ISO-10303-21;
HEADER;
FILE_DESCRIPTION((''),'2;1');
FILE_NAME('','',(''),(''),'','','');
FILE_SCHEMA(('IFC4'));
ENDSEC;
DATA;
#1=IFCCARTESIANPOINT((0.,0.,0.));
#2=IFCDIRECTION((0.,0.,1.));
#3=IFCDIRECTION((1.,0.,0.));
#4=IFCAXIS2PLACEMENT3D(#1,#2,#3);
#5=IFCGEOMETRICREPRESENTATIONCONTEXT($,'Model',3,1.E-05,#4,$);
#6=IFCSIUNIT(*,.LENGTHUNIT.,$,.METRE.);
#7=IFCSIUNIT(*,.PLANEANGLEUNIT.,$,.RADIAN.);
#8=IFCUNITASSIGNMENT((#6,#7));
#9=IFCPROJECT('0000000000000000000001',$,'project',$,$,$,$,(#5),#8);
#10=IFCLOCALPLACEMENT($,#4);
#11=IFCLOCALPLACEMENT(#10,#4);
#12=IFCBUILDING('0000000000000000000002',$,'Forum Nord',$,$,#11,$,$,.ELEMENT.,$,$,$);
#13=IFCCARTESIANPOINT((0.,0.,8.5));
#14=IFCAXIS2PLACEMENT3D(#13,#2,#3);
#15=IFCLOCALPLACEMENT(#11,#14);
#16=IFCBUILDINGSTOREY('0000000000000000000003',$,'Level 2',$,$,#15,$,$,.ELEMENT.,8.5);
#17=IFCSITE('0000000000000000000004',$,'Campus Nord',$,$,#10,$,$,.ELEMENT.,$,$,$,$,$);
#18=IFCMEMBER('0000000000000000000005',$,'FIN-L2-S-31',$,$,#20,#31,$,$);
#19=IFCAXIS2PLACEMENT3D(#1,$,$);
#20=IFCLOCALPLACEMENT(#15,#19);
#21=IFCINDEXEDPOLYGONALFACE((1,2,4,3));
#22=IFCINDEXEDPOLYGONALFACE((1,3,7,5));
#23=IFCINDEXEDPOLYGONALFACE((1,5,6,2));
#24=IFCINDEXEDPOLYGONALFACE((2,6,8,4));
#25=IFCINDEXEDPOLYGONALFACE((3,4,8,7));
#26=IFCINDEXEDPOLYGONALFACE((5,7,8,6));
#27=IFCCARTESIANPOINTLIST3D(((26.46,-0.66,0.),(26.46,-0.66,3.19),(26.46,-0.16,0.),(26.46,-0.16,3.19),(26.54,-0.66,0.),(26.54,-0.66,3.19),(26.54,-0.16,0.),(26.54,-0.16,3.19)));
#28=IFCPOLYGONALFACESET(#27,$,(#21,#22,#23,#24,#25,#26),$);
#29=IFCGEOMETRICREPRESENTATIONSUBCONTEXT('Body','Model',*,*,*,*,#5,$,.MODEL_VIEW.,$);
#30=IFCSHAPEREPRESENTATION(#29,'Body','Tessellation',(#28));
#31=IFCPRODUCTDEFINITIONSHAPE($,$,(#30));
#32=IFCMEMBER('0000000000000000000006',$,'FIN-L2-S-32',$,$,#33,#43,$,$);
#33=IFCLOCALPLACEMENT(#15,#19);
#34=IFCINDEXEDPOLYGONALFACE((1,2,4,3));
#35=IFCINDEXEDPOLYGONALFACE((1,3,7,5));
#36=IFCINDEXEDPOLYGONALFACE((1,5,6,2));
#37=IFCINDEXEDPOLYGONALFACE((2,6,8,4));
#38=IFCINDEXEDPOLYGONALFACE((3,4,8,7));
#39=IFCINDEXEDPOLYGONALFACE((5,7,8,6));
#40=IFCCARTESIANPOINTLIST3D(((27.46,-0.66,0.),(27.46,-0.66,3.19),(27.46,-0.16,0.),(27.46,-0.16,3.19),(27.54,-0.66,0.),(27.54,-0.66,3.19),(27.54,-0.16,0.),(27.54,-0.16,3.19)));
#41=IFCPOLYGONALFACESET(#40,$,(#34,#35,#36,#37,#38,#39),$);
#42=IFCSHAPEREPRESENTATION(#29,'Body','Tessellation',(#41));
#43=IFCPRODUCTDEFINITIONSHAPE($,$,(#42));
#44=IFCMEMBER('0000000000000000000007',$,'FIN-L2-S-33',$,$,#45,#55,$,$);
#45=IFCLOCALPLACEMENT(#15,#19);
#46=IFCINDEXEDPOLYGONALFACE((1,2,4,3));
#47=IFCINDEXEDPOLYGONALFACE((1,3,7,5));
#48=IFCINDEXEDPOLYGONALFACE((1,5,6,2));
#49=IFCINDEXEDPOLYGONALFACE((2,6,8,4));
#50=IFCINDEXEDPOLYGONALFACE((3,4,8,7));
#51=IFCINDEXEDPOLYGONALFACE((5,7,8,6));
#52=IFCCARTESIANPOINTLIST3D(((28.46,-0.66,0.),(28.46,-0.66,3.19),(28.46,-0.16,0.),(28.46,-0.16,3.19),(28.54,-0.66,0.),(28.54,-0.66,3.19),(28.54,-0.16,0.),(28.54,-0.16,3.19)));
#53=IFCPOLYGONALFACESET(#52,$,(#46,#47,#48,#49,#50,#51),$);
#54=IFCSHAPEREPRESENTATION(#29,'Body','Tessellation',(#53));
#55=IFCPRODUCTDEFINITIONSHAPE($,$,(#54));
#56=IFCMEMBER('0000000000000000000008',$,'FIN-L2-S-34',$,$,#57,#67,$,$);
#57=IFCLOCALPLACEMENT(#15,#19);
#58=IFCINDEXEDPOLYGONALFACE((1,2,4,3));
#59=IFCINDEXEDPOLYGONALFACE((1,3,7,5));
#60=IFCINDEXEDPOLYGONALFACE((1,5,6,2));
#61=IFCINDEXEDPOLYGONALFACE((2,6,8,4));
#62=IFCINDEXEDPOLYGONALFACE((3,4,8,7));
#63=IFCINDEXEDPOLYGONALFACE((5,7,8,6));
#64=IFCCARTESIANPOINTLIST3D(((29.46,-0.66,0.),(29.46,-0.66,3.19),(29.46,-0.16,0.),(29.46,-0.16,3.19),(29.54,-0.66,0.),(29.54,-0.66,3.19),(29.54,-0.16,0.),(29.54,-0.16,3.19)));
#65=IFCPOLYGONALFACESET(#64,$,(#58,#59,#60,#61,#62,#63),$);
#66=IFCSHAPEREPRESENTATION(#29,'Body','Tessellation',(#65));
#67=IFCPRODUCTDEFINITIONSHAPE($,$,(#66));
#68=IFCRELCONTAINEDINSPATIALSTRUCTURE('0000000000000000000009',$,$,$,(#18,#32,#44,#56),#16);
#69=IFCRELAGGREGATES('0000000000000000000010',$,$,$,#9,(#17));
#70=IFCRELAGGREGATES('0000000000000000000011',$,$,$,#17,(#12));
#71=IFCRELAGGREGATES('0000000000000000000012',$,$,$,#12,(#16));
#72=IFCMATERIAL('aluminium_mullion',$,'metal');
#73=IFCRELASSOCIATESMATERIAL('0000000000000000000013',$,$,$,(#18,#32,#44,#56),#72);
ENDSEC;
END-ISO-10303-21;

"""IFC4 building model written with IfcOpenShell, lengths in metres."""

from ifc_helpers import new_model, si_unit, frame, origin_with_axes, place, context, subcontext, project, spatial, polyline, outline, extrude, material, element, save


model = new_model("IFC4")

# Units and contexts
model_context = context("Model", 3, precision=1e-05, world=origin_with_axes())
body_context = subcontext(model_context, "Body", "Model", "MODEL_VIEW")
ifc_project = project(units=[si_unit("LENGTHUNIT", "METRE"), si_unit("PLANEANGLEUNIT", "RADIAN")], contexts=[model_context])

# Site, building, storey
site_placement = place(None, origin_with_axes())
site = spatial("IfcSite", under=ifc_project, at=site_placement, Name="Campus Nord", CompositionType="ELEMENT")
building_placement = place(site_placement, origin_with_axes())
building = spatial("IfcBuilding", under=site, at=building_placement, Name="Forum Nord", CompositionType="ELEMENT")
storey_placement = place(building_placement, frame((0.0, 0.0, 8.5), z_axis=(0.0, 0.0, 1.0), x_axis=(1.0, 0.0, 0.0)))
storey = spatial("IfcBuildingStorey", under=building, at=storey_placement, Name="Level 2", CompositionType="ELEMENT", Elevation=8.5)

# Members
ifc_material = material(Name="aluminium_mullion", Category="metal")
member_1_placement = place(storey_placement, origin_with_axes())
element("IfcMember", 1, at=member_1_placement, inside=storey, material=ifc_material, Name="FIN-L2-S-31", context=body_context, shape_type="SweptSolid", body=[
    extrude(outline(polyline([(26.46, -0.66), (26.54, -0.66), (26.54, -0.16), (26.46, -0.16), (26.46, -0.66)])), origin_with_axes(), (0.0, 0.0, 1.0), 3.19),
])
member_2_placement = place(storey_placement, origin_with_axes())
element("IfcMember", 2, at=member_2_placement, inside=storey, material=ifc_material, Name="FIN-L2-S-32", context=body_context, shape_type="SweptSolid", body=[
    extrude(outline(polyline([(27.46, -0.66), (27.54, -0.66), (27.54, -0.16), (27.46, -0.16), (27.46, -0.66)])), origin_with_axes(), (0.0, 0.0, 1.0), 3.19),
])
member_3_placement = place(storey_placement, origin_with_axes())
element("IfcMember", 3, at=member_3_placement, inside=storey, material=ifc_material, Name="FIN-L2-S-33", context=body_context, shape_type="SweptSolid", body=[
    extrude(outline(polyline([(28.46, -0.66), (28.54, -0.66), (28.54, -0.16), (28.46, -0.16), (28.46, -0.66)])), origin_with_axes(), (0.0, 0.0, 1.0), 3.19),
])
member_4_placement = place(storey_placement, origin_with_axes())
element("IfcMember", 4, at=member_4_placement, inside=storey, material=ifc_material, Name="FIN-L2-S-34", context=body_context, shape_type="SweptSolid", body=[
    extrude(outline(polyline([(29.46, -0.66), (29.54, -0.66), (29.54, -0.16), (29.46, -0.16), (29.46, -0.66)])), origin_with_axes(), (0.0, 0.0, 1.0), 3.19),
])

save(model, "model.ifc")
